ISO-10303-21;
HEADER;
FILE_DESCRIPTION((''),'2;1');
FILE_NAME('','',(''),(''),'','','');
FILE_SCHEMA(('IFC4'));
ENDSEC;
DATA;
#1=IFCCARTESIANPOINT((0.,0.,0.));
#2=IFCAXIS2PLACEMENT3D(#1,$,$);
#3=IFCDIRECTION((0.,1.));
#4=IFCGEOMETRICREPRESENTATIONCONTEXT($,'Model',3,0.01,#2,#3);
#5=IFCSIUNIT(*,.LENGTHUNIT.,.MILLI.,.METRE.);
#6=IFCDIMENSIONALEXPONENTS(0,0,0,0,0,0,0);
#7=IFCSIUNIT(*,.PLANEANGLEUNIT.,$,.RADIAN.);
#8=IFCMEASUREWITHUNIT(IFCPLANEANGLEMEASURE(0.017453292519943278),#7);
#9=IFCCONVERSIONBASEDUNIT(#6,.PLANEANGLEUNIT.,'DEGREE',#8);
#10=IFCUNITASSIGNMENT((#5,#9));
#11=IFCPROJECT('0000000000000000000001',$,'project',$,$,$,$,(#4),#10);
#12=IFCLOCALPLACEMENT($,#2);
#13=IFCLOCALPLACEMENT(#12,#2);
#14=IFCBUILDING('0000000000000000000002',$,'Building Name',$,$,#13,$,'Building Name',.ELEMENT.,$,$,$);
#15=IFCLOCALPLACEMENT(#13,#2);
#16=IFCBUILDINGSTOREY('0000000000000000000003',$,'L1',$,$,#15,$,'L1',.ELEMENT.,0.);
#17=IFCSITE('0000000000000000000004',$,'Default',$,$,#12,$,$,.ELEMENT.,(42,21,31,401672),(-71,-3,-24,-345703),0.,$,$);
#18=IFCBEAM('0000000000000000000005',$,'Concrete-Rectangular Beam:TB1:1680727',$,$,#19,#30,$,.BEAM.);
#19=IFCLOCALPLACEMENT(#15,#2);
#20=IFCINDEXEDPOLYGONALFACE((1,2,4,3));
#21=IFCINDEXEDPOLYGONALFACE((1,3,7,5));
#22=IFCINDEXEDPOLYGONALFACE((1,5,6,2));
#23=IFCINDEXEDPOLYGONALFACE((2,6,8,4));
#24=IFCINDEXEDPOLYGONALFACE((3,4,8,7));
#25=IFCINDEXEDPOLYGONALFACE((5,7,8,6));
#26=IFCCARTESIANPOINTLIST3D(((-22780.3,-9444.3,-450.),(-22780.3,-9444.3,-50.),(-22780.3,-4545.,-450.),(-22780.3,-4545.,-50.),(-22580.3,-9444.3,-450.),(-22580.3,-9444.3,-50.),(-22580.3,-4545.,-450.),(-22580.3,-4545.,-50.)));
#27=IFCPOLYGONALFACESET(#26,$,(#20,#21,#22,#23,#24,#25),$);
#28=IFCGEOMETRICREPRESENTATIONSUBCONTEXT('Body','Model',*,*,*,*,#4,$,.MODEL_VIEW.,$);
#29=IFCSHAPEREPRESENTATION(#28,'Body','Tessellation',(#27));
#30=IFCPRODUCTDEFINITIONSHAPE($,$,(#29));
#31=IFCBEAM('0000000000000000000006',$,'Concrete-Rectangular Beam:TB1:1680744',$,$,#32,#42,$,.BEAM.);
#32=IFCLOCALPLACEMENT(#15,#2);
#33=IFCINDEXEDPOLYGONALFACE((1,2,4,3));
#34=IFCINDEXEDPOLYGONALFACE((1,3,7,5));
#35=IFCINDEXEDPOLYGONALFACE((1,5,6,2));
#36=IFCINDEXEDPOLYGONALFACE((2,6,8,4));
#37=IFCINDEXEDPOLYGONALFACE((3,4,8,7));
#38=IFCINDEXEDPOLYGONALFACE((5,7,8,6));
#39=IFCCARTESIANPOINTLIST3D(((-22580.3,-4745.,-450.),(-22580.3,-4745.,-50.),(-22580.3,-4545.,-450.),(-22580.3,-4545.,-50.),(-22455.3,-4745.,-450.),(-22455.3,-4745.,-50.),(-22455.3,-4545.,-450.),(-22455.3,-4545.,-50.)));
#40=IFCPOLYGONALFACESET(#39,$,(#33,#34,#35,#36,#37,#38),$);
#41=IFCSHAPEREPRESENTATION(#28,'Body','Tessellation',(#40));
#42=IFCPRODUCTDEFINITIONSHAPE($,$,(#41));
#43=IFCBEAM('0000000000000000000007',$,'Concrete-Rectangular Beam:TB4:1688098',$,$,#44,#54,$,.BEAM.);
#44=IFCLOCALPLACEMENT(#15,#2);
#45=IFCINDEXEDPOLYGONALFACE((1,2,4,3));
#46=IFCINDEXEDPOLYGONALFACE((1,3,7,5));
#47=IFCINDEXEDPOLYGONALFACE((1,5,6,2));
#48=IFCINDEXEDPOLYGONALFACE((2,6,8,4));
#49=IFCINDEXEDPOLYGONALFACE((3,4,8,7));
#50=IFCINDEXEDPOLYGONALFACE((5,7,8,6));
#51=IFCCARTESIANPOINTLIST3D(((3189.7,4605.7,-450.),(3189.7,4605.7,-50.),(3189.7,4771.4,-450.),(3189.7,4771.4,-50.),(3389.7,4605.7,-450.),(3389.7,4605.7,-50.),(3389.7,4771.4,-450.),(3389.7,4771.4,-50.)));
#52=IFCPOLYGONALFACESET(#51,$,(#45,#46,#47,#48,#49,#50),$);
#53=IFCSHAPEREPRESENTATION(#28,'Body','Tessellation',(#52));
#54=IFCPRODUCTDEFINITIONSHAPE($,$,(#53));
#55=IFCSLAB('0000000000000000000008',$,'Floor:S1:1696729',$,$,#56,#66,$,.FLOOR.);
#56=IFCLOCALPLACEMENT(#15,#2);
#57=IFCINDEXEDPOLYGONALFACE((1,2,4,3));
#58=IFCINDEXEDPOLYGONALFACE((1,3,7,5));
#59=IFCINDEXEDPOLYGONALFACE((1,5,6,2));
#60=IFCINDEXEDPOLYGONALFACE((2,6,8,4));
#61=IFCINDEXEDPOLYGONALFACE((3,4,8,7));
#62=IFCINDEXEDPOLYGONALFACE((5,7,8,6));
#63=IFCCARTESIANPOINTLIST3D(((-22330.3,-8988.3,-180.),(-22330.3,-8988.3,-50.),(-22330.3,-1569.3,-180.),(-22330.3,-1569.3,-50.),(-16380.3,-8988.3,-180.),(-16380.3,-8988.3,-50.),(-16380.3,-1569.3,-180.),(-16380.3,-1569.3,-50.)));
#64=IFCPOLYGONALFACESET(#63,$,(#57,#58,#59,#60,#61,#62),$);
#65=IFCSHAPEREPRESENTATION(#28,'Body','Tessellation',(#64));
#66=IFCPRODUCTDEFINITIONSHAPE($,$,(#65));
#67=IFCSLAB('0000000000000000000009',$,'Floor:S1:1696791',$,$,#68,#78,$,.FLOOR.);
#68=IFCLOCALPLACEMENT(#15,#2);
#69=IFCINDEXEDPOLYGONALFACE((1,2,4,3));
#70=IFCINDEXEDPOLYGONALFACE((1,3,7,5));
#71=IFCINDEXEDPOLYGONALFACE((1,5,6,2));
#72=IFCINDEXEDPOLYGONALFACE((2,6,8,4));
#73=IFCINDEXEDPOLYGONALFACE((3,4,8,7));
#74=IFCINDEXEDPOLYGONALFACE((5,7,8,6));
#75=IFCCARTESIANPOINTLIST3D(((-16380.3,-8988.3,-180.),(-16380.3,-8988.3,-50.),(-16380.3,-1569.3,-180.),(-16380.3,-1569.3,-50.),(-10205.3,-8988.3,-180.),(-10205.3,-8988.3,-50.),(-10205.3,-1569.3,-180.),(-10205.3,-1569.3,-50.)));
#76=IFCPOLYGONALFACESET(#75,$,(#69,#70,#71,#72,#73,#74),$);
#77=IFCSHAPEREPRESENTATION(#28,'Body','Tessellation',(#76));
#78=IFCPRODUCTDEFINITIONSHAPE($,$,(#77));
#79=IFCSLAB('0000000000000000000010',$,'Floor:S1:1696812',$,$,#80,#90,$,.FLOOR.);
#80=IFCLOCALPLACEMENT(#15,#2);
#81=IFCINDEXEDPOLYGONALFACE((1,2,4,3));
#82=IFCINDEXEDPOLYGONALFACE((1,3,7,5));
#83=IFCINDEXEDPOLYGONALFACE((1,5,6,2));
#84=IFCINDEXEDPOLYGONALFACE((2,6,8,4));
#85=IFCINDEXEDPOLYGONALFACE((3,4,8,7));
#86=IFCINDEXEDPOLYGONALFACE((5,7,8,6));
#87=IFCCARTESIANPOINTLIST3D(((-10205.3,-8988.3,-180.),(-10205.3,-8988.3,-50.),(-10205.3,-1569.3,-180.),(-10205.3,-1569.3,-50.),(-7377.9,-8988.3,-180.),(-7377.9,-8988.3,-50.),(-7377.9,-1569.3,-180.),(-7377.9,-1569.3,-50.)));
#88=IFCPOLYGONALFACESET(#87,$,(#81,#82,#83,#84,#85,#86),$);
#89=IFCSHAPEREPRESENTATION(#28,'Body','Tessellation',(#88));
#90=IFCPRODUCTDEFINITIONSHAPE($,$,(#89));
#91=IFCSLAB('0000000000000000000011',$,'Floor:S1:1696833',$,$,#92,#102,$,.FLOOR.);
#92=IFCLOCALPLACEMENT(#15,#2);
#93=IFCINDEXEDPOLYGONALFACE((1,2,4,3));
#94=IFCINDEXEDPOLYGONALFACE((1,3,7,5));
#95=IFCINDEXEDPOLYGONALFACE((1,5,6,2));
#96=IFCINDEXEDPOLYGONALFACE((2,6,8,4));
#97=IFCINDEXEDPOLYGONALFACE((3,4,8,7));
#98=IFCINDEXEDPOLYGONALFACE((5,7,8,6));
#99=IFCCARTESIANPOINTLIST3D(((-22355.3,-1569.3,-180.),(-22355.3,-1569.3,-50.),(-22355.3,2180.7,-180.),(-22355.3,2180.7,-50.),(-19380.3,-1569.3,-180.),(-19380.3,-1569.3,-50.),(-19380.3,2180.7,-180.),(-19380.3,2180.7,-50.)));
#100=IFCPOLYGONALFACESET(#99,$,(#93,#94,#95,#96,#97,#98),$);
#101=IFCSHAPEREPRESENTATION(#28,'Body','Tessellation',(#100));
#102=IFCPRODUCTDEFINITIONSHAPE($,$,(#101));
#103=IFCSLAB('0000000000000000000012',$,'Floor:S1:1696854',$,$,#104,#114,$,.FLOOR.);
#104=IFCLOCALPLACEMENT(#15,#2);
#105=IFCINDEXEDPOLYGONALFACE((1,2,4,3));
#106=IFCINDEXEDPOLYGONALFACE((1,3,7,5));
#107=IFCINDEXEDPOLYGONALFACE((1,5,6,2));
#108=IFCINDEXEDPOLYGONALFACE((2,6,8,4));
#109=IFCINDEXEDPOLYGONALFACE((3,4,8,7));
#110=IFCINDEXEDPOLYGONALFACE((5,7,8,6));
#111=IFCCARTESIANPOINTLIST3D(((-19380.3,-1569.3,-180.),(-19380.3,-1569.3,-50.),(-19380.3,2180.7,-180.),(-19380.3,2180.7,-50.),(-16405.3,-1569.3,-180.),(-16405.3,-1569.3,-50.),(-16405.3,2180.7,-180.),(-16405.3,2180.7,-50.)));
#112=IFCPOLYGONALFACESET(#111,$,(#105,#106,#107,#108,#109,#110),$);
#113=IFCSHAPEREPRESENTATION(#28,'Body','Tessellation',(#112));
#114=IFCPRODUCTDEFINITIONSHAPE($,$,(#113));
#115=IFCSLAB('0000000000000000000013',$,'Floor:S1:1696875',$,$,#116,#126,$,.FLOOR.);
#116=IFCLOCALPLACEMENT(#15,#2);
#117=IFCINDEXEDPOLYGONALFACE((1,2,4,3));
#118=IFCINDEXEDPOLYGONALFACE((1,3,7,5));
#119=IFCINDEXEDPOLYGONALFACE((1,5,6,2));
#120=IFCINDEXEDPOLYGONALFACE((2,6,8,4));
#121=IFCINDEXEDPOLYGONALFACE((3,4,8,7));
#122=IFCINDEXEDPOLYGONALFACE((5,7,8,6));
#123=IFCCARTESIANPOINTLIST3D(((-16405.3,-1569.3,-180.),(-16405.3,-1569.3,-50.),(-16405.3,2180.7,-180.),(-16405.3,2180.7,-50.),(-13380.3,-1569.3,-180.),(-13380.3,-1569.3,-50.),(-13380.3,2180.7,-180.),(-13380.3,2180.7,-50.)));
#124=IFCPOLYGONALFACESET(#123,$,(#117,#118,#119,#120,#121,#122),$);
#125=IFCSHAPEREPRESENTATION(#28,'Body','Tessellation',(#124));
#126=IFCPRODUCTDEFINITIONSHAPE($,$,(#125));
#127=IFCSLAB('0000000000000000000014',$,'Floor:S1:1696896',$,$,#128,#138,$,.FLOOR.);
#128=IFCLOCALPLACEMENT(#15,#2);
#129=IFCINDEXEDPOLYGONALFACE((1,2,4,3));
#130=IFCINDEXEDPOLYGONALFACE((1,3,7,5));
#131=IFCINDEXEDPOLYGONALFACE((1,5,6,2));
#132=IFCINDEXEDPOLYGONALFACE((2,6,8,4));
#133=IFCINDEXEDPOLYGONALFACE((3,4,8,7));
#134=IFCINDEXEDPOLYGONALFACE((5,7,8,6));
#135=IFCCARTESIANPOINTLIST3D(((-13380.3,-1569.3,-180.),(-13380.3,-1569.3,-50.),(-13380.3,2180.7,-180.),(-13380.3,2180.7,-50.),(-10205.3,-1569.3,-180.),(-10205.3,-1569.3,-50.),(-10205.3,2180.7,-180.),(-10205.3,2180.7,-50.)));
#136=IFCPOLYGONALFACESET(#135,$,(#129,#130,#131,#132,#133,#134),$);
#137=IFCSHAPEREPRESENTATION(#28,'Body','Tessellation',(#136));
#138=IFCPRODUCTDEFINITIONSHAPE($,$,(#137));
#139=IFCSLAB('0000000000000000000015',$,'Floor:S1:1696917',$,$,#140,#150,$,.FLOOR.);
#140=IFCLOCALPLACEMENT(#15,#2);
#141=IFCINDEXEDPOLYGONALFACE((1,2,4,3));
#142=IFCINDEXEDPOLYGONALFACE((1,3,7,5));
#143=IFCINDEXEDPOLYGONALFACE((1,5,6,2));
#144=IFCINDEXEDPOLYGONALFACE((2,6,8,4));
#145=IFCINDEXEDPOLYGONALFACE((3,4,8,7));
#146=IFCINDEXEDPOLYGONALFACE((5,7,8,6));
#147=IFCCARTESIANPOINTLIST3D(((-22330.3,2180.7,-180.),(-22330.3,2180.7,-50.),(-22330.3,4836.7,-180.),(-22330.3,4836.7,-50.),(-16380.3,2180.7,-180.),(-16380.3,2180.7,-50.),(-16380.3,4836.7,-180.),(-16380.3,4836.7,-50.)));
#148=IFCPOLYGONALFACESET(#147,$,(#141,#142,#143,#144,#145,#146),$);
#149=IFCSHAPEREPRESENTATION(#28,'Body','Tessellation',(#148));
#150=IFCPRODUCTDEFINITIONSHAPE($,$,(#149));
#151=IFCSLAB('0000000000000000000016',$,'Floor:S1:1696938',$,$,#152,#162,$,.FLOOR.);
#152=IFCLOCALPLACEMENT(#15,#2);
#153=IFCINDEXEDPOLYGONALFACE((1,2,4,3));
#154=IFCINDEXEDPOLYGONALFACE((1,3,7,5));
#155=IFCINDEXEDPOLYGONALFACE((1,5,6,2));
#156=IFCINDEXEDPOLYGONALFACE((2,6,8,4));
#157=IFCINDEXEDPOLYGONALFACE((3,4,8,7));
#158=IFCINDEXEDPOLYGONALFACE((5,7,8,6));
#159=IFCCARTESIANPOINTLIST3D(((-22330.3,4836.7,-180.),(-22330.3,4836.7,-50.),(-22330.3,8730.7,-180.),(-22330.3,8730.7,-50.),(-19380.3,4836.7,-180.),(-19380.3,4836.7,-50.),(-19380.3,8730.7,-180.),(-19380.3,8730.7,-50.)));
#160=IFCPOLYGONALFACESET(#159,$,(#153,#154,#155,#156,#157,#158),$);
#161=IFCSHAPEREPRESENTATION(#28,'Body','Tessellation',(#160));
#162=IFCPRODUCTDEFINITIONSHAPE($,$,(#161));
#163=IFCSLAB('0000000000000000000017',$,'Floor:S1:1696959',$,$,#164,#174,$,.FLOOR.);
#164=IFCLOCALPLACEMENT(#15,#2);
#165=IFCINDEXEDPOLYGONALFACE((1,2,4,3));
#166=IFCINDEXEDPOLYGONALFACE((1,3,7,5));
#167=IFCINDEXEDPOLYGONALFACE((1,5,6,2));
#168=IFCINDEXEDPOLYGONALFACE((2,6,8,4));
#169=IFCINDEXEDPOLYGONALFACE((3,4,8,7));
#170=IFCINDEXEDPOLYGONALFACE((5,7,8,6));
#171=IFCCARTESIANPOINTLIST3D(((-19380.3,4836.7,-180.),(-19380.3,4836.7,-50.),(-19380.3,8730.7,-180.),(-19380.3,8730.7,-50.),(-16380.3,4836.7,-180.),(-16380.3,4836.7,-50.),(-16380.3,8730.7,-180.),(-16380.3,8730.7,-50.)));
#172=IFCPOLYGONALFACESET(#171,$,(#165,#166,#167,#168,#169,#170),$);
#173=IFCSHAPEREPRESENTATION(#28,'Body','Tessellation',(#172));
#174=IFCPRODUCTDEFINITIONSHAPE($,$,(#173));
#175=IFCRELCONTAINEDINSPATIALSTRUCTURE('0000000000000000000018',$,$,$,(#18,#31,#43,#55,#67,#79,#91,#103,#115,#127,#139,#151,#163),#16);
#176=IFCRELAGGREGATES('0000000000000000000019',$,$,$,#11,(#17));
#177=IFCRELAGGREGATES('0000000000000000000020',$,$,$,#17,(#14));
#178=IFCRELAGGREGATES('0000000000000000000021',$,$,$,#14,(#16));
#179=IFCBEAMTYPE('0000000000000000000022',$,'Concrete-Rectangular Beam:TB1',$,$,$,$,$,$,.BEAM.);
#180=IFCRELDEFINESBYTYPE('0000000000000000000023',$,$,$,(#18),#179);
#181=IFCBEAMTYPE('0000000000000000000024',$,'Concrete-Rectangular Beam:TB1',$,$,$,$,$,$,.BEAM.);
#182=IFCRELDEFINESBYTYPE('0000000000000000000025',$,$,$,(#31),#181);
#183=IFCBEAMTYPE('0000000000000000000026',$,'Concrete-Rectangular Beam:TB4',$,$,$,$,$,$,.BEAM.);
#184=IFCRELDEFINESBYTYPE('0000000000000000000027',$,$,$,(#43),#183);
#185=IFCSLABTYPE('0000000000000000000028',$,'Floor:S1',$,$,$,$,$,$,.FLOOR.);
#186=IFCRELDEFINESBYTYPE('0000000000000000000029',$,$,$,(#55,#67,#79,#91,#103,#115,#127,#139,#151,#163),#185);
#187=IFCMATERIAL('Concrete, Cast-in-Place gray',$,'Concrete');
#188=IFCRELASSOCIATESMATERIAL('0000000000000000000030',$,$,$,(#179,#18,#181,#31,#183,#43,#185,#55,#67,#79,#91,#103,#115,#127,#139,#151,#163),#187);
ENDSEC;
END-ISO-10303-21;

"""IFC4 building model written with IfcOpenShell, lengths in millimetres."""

from ifc_helpers import new_model, entity, si_unit, converted_unit, direction, frame, origin, place, context, subcontext, project, spatial, indexed_curve, outline, extrude, source, transform, mapped, material, type_object, type_shapes, element, save


model = new_model("IFC4")

# Units and contexts
model_context = context("Model", 3, precision=0.01, world=origin(), true_north=direction((0.0, 1.0)))
body_context = subcontext(model_context, "Body", "Model", "MODEL_VIEW")
ifc_project = project(units=[si_unit("LENGTHUNIT", "METRE", prefix="MILLI"), converted_unit("PLANEANGLEUNIT", "DEGREE", entity("IfcPlaneAngleMeasure", 0.017453292519943278), si_unit("PLANEANGLEUNIT", "RADIAN"), dimensions=[0, 0, 0, 0, 0, 0, 0])], contexts=[model_context])

# Site, building, storey
site_placement = place(None, origin())
site = spatial("IfcSite", under=ifc_project, at=site_placement, Name="Default", CompositionType="ELEMENT", RefLatitude=(42, 21, 31, 401672), RefLongitude=(-71, -3, -24, -345703), RefElevation=0.0)
building_placement = place(site_placement, origin())
building = spatial("IfcBuilding", under=site, at=building_placement, Name="Building Name", LongName="Building Name", CompositionType="ELEMENT")
storey_placement = place(building_placement, origin())
storey = spatial("IfcBuildingStorey", under=building, at=storey_placement, Name="L1", LongName="L1", CompositionType="ELEMENT", Elevation=0.0)

# Beams
ifc_material = material(Name="Concrete, Cast-in-Place gray", Category="Concrete")
beam_type_1 = type_object("IfcBeamType", Name="Concrete-Rectangular Beam:TB1", PredefinedType="BEAM", material=ifc_material)
shared_shape_1 = source(origin(), body_context, "Body", "SweptSolid", [
    extrude(outline(indexed_curve([(-100.0, -200.0), (100.0, -200.0), (100.0, 200.0), (-100.0, 200.0), (-100.0, -200.0)], self_intersect=False)), frame((-22680.3, -9444.3, -250.0), z_axis=(0.0, 1.0, 0.0), x_axis=(-1.0, 0.0, 0.0)), (0.0, 0.0, 1.0), 4899.3),
])
type_shapes(beam_type_1, [shared_shape_1])
beam_1_placement = place(storey_placement, origin())
element("IfcBeam", 1, at=beam_1_placement, inside=storey, type_object=beam_type_1, material=ifc_material, Name="Concrete-Rectangular Beam:TB1:1680727", PredefinedType="BEAM", context=body_context, shape_type="MappedRepresentation", body=[
    mapped(shared_shape_1, transform((0.0, 0.0, 0.0), scale=1.0)),
])
beam_type_2 = type_object("IfcBeamType", Name="Concrete-Rectangular Beam:TB1", PredefinedType="BEAM", material=ifc_material)
shared_shape_2 = source(origin(), body_context, "Body", "SweptSolid", [
    extrude(outline(indexed_curve([(-200.0, -100.0), (200.0, -100.0), (200.0, 100.0), (-200.0, 100.0), (-200.0, -100.0)], self_intersect=False)), frame((-22580.3, -4645.0, -250.0), z_axis=(1.0, 0.0, 0.0), x_axis=(0.0, 0.0, -1.0)), (0.0, 0.0, 1.0), 125.0),
])
type_shapes(beam_type_2, [shared_shape_2])
beam_2_placement = place(storey_placement, origin())
element("IfcBeam", 2, at=beam_2_placement, inside=storey, type_object=beam_type_2, material=ifc_material, Name="Concrete-Rectangular Beam:TB1:1680744", PredefinedType="BEAM", context=body_context, shape_type="MappedRepresentation", body=[
    mapped(shared_shape_2, transform((0.0, 0.0, 0.0), scale=1.0)),
])
beam_type_3 = type_object("IfcBeamType", Name="Concrete-Rectangular Beam:TB4", PredefinedType="BEAM", material=ifc_material)
shared_shape_3 = source(origin(), body_context, "Body", "SweptSolid", [
    extrude(outline(indexed_curve([(-100.0, -200.0), (100.0, -200.0), (100.0, 200.0), (-100.0, 200.0), (-100.0, -200.0)], self_intersect=False)), frame((3289.7, 4605.7, -250.0), z_axis=(0.0, 1.0, 0.0), x_axis=(-1.0, 0.0, 0.0)), (0.0, 0.0, 1.0), 165.8),
])
type_shapes(beam_type_3, [shared_shape_3])
beam_3_placement = place(storey_placement, origin())
element("IfcBeam", 3, at=beam_3_placement, inside=storey, type_object=beam_type_3, material=ifc_material, Name="Concrete-Rectangular Beam:TB4:1688098", PredefinedType="BEAM", context=body_context, shape_type="MappedRepresentation", body=[
    mapped(shared_shape_3, transform((0.0, 0.0, 0.0), scale=1.0)),
])

# Slabs
slab_type = type_object("IfcSlabType", Name="Floor:S1", PredefinedType="FLOOR", material=ifc_material)
slab_1_placement = place(storey_placement, origin())
element("IfcSlab", 4, at=slab_1_placement, inside=storey, type_object=slab_type, material=ifc_material, Name="Floor:S1:1696729", PredefinedType="FLOOR", context=body_context, shape_type="SweptSolid", body=[
    extrude(outline(indexed_curve([(-3709.5, -2975.0), (3709.5, -2975.0), (3709.5, 2975.0), (-3709.5, 2975.0), (-3709.5, -2975.0)], self_intersect=False)), frame((-19355.3, -5278.8, -50.0), z_axis=(0.0, 0.0, -1.0), x_axis=(0.0, 1.0, 0.0)), (0.0, 0.0, 1.0), 130.0),
])
slab_2_placement = place(storey_placement, origin())
element("IfcSlab", 5, at=slab_2_placement, inside=storey, type_object=slab_type, material=ifc_material, Name="Floor:S1:1696791", PredefinedType="FLOOR", context=body_context, shape_type="SweptSolid", body=[
    extrude(outline(indexed_curve([(-3709.5, -3087.5), (3709.5, -3087.5), (3709.5, 3087.5), (-3709.5, 3087.5), (-3709.5, -3087.5)], self_intersect=False)), frame((-13292.8, -5278.8, -50.0), z_axis=(0.0, 0.0, -1.0), x_axis=(0.0, 1.0, 0.0)), (0.0, 0.0, 1.0), 130.0),
])
slab_3_placement = place(storey_placement, origin())
element("IfcSlab", 6, at=slab_3_placement, inside=storey, type_object=slab_type, material=ifc_material, Name="Floor:S1:1696812", PredefinedType="FLOOR", context=body_context, shape_type="SweptSolid", body=[
    extrude(outline(indexed_curve([(-3709.5, -1413.7), (3709.5, -1413.7), (3709.5, 1413.7), (-3709.5, 1413.7), (-3709.5, -1413.7)], self_intersect=False)), frame((-8791.6, -5278.8, -50.0), z_axis=(0.0, 0.0, -1.0), x_axis=(0.0, 1.0, 0.0)), (0.0, 0.0, 1.0), 130.0),
])
slab_4_placement = place(storey_placement, origin())
element("IfcSlab", 7, at=slab_4_placement, inside=storey, type_object=slab_type, material=ifc_material, Name="Floor:S1:1696833", PredefinedType="FLOOR", context=body_context, shape_type="SweptSolid", body=[
    extrude(outline(indexed_curve([(-1875.0, -1487.5), (1875.0, -1487.5), (1875.0, 1487.5), (-1875.0, 1487.5), (-1875.0, -1487.5)], self_intersect=False)), frame((-20867.8, 305.7, -50.0), z_axis=(0.0, 0.0, -1.0), x_axis=(0.0, 1.0, 0.0)), (0.0, 0.0, 1.0), 130.0),
])
slab_5_placement = place(storey_placement, origin())
element("IfcSlab", 8, at=slab_5_placement, inside=storey, type_object=slab_type, material=ifc_material, Name="Floor:S1:1696854", PredefinedType="FLOOR", context=body_context, shape_type="SweptSolid", body=[
    extrude(outline(indexed_curve([(-1875.0, -1487.5), (1875.0, -1487.5), (1875.0, 1487.5), (-1875.0, 1487.5), (-1875.0, -1487.5)], self_intersect=False)), frame((-17892.8, 305.7, -50.0), z_axis=(0.0, 0.0, -1.0), x_axis=(0.0, 1.0, 0.0)), (0.0, 0.0, 1.0), 130.0),
])
slab_6_placement = place(storey_placement, origin())
element("IfcSlab", 9, at=slab_6_placement, inside=storey, type_object=slab_type, material=ifc_material, Name="Floor:S1:1696875", PredefinedType="FLOOR", context=body_context, shape_type="SweptSolid", body=[
    extrude(outline(indexed_curve([(-1875.0, -1512.5), (1875.0, -1512.5), (1875.0, 1512.5), (-1875.0, 1512.5), (-1875.0, -1512.5)], self_intersect=False)), frame((-14892.8, 305.7, -50.0), z_axis=(0.0, 0.0, -1.0), x_axis=(0.0, 1.0, 0.0)), (0.0, 0.0, 1.0), 130.0),
])
slab_7_placement = place(storey_placement, origin())
element("IfcSlab", 10, at=slab_7_placement, inside=storey, type_object=slab_type, material=ifc_material, Name="Floor:S1:1696896", PredefinedType="FLOOR", context=body_context, shape_type="SweptSolid", body=[
    extrude(outline(indexed_curve([(-1875.0, -1587.5), (1875.0, -1587.5), (1875.0, 1587.5), (-1875.0, 1587.5), (-1875.0, -1587.5)], self_intersect=False)), frame((-11792.8, 305.7, -50.0), z_axis=(0.0, 0.0, -1.0), x_axis=(0.0, 1.0, 0.0)), (0.0, 0.0, 1.0), 130.0),
])
slab_8_placement = place(storey_placement, origin())
element("IfcSlab", 11, at=slab_8_placement, inside=storey, type_object=slab_type, material=ifc_material, Name="Floor:S1:1696917", PredefinedType="FLOOR", context=body_context, shape_type="SweptSolid", body=[
    extrude(outline(indexed_curve([(-1328.0, -2975.0), (1328.0, -2975.0), (1328.0, 2975.0), (-1328.0, 2975.0), (-1328.0, -2975.0)], self_intersect=False)), frame((-19355.3, 3508.7, -50.0), z_axis=(0.0, 0.0, -1.0), x_axis=(0.0, 1.0, 0.0)), (0.0, 0.0, 1.0), 130.0),
])
slab_9_placement = place(storey_placement, origin())
element("IfcSlab", 12, at=slab_9_placement, inside=storey, type_object=slab_type, material=ifc_material, Name="Floor:S1:1696938", PredefinedType="FLOOR", context=body_context, shape_type="SweptSolid", body=[
    extrude(outline(indexed_curve([(-1947.0, -1475.0), (1947.0, -1475.0), (1947.0, 1475.0), (-1947.0, 1475.0), (-1947.0, -1475.0)], self_intersect=False)), frame((-20855.3, 6783.7, -50.0), z_axis=(0.0, 0.0, -1.0), x_axis=(0.0, 1.0, 0.0)), (0.0, 0.0, 1.0), 130.0),
])
slab_10_placement = place(storey_placement, origin())
element("IfcSlab", 13, at=slab_10_placement, inside=storey, type_object=slab_type, material=ifc_material, Name="Floor:S1:1696959", PredefinedType="FLOOR", context=body_context, shape_type="SweptSolid", body=[
    extrude(outline(indexed_curve([(-1947.0, -1500.0), (1947.0, -1500.0), (1947.0, 1500.0), (-1947.0, 1500.0), (-1947.0, -1500.0)], self_intersect=False)), frame((-17880.3, 6783.7, -50.0), z_axis=(0.0, 0.0, -1.0), x_axis=(0.0, 1.0, 0.0)), (0.0, 0.0, 1.0), 130.0),
])

save(model, "model.ifc")
